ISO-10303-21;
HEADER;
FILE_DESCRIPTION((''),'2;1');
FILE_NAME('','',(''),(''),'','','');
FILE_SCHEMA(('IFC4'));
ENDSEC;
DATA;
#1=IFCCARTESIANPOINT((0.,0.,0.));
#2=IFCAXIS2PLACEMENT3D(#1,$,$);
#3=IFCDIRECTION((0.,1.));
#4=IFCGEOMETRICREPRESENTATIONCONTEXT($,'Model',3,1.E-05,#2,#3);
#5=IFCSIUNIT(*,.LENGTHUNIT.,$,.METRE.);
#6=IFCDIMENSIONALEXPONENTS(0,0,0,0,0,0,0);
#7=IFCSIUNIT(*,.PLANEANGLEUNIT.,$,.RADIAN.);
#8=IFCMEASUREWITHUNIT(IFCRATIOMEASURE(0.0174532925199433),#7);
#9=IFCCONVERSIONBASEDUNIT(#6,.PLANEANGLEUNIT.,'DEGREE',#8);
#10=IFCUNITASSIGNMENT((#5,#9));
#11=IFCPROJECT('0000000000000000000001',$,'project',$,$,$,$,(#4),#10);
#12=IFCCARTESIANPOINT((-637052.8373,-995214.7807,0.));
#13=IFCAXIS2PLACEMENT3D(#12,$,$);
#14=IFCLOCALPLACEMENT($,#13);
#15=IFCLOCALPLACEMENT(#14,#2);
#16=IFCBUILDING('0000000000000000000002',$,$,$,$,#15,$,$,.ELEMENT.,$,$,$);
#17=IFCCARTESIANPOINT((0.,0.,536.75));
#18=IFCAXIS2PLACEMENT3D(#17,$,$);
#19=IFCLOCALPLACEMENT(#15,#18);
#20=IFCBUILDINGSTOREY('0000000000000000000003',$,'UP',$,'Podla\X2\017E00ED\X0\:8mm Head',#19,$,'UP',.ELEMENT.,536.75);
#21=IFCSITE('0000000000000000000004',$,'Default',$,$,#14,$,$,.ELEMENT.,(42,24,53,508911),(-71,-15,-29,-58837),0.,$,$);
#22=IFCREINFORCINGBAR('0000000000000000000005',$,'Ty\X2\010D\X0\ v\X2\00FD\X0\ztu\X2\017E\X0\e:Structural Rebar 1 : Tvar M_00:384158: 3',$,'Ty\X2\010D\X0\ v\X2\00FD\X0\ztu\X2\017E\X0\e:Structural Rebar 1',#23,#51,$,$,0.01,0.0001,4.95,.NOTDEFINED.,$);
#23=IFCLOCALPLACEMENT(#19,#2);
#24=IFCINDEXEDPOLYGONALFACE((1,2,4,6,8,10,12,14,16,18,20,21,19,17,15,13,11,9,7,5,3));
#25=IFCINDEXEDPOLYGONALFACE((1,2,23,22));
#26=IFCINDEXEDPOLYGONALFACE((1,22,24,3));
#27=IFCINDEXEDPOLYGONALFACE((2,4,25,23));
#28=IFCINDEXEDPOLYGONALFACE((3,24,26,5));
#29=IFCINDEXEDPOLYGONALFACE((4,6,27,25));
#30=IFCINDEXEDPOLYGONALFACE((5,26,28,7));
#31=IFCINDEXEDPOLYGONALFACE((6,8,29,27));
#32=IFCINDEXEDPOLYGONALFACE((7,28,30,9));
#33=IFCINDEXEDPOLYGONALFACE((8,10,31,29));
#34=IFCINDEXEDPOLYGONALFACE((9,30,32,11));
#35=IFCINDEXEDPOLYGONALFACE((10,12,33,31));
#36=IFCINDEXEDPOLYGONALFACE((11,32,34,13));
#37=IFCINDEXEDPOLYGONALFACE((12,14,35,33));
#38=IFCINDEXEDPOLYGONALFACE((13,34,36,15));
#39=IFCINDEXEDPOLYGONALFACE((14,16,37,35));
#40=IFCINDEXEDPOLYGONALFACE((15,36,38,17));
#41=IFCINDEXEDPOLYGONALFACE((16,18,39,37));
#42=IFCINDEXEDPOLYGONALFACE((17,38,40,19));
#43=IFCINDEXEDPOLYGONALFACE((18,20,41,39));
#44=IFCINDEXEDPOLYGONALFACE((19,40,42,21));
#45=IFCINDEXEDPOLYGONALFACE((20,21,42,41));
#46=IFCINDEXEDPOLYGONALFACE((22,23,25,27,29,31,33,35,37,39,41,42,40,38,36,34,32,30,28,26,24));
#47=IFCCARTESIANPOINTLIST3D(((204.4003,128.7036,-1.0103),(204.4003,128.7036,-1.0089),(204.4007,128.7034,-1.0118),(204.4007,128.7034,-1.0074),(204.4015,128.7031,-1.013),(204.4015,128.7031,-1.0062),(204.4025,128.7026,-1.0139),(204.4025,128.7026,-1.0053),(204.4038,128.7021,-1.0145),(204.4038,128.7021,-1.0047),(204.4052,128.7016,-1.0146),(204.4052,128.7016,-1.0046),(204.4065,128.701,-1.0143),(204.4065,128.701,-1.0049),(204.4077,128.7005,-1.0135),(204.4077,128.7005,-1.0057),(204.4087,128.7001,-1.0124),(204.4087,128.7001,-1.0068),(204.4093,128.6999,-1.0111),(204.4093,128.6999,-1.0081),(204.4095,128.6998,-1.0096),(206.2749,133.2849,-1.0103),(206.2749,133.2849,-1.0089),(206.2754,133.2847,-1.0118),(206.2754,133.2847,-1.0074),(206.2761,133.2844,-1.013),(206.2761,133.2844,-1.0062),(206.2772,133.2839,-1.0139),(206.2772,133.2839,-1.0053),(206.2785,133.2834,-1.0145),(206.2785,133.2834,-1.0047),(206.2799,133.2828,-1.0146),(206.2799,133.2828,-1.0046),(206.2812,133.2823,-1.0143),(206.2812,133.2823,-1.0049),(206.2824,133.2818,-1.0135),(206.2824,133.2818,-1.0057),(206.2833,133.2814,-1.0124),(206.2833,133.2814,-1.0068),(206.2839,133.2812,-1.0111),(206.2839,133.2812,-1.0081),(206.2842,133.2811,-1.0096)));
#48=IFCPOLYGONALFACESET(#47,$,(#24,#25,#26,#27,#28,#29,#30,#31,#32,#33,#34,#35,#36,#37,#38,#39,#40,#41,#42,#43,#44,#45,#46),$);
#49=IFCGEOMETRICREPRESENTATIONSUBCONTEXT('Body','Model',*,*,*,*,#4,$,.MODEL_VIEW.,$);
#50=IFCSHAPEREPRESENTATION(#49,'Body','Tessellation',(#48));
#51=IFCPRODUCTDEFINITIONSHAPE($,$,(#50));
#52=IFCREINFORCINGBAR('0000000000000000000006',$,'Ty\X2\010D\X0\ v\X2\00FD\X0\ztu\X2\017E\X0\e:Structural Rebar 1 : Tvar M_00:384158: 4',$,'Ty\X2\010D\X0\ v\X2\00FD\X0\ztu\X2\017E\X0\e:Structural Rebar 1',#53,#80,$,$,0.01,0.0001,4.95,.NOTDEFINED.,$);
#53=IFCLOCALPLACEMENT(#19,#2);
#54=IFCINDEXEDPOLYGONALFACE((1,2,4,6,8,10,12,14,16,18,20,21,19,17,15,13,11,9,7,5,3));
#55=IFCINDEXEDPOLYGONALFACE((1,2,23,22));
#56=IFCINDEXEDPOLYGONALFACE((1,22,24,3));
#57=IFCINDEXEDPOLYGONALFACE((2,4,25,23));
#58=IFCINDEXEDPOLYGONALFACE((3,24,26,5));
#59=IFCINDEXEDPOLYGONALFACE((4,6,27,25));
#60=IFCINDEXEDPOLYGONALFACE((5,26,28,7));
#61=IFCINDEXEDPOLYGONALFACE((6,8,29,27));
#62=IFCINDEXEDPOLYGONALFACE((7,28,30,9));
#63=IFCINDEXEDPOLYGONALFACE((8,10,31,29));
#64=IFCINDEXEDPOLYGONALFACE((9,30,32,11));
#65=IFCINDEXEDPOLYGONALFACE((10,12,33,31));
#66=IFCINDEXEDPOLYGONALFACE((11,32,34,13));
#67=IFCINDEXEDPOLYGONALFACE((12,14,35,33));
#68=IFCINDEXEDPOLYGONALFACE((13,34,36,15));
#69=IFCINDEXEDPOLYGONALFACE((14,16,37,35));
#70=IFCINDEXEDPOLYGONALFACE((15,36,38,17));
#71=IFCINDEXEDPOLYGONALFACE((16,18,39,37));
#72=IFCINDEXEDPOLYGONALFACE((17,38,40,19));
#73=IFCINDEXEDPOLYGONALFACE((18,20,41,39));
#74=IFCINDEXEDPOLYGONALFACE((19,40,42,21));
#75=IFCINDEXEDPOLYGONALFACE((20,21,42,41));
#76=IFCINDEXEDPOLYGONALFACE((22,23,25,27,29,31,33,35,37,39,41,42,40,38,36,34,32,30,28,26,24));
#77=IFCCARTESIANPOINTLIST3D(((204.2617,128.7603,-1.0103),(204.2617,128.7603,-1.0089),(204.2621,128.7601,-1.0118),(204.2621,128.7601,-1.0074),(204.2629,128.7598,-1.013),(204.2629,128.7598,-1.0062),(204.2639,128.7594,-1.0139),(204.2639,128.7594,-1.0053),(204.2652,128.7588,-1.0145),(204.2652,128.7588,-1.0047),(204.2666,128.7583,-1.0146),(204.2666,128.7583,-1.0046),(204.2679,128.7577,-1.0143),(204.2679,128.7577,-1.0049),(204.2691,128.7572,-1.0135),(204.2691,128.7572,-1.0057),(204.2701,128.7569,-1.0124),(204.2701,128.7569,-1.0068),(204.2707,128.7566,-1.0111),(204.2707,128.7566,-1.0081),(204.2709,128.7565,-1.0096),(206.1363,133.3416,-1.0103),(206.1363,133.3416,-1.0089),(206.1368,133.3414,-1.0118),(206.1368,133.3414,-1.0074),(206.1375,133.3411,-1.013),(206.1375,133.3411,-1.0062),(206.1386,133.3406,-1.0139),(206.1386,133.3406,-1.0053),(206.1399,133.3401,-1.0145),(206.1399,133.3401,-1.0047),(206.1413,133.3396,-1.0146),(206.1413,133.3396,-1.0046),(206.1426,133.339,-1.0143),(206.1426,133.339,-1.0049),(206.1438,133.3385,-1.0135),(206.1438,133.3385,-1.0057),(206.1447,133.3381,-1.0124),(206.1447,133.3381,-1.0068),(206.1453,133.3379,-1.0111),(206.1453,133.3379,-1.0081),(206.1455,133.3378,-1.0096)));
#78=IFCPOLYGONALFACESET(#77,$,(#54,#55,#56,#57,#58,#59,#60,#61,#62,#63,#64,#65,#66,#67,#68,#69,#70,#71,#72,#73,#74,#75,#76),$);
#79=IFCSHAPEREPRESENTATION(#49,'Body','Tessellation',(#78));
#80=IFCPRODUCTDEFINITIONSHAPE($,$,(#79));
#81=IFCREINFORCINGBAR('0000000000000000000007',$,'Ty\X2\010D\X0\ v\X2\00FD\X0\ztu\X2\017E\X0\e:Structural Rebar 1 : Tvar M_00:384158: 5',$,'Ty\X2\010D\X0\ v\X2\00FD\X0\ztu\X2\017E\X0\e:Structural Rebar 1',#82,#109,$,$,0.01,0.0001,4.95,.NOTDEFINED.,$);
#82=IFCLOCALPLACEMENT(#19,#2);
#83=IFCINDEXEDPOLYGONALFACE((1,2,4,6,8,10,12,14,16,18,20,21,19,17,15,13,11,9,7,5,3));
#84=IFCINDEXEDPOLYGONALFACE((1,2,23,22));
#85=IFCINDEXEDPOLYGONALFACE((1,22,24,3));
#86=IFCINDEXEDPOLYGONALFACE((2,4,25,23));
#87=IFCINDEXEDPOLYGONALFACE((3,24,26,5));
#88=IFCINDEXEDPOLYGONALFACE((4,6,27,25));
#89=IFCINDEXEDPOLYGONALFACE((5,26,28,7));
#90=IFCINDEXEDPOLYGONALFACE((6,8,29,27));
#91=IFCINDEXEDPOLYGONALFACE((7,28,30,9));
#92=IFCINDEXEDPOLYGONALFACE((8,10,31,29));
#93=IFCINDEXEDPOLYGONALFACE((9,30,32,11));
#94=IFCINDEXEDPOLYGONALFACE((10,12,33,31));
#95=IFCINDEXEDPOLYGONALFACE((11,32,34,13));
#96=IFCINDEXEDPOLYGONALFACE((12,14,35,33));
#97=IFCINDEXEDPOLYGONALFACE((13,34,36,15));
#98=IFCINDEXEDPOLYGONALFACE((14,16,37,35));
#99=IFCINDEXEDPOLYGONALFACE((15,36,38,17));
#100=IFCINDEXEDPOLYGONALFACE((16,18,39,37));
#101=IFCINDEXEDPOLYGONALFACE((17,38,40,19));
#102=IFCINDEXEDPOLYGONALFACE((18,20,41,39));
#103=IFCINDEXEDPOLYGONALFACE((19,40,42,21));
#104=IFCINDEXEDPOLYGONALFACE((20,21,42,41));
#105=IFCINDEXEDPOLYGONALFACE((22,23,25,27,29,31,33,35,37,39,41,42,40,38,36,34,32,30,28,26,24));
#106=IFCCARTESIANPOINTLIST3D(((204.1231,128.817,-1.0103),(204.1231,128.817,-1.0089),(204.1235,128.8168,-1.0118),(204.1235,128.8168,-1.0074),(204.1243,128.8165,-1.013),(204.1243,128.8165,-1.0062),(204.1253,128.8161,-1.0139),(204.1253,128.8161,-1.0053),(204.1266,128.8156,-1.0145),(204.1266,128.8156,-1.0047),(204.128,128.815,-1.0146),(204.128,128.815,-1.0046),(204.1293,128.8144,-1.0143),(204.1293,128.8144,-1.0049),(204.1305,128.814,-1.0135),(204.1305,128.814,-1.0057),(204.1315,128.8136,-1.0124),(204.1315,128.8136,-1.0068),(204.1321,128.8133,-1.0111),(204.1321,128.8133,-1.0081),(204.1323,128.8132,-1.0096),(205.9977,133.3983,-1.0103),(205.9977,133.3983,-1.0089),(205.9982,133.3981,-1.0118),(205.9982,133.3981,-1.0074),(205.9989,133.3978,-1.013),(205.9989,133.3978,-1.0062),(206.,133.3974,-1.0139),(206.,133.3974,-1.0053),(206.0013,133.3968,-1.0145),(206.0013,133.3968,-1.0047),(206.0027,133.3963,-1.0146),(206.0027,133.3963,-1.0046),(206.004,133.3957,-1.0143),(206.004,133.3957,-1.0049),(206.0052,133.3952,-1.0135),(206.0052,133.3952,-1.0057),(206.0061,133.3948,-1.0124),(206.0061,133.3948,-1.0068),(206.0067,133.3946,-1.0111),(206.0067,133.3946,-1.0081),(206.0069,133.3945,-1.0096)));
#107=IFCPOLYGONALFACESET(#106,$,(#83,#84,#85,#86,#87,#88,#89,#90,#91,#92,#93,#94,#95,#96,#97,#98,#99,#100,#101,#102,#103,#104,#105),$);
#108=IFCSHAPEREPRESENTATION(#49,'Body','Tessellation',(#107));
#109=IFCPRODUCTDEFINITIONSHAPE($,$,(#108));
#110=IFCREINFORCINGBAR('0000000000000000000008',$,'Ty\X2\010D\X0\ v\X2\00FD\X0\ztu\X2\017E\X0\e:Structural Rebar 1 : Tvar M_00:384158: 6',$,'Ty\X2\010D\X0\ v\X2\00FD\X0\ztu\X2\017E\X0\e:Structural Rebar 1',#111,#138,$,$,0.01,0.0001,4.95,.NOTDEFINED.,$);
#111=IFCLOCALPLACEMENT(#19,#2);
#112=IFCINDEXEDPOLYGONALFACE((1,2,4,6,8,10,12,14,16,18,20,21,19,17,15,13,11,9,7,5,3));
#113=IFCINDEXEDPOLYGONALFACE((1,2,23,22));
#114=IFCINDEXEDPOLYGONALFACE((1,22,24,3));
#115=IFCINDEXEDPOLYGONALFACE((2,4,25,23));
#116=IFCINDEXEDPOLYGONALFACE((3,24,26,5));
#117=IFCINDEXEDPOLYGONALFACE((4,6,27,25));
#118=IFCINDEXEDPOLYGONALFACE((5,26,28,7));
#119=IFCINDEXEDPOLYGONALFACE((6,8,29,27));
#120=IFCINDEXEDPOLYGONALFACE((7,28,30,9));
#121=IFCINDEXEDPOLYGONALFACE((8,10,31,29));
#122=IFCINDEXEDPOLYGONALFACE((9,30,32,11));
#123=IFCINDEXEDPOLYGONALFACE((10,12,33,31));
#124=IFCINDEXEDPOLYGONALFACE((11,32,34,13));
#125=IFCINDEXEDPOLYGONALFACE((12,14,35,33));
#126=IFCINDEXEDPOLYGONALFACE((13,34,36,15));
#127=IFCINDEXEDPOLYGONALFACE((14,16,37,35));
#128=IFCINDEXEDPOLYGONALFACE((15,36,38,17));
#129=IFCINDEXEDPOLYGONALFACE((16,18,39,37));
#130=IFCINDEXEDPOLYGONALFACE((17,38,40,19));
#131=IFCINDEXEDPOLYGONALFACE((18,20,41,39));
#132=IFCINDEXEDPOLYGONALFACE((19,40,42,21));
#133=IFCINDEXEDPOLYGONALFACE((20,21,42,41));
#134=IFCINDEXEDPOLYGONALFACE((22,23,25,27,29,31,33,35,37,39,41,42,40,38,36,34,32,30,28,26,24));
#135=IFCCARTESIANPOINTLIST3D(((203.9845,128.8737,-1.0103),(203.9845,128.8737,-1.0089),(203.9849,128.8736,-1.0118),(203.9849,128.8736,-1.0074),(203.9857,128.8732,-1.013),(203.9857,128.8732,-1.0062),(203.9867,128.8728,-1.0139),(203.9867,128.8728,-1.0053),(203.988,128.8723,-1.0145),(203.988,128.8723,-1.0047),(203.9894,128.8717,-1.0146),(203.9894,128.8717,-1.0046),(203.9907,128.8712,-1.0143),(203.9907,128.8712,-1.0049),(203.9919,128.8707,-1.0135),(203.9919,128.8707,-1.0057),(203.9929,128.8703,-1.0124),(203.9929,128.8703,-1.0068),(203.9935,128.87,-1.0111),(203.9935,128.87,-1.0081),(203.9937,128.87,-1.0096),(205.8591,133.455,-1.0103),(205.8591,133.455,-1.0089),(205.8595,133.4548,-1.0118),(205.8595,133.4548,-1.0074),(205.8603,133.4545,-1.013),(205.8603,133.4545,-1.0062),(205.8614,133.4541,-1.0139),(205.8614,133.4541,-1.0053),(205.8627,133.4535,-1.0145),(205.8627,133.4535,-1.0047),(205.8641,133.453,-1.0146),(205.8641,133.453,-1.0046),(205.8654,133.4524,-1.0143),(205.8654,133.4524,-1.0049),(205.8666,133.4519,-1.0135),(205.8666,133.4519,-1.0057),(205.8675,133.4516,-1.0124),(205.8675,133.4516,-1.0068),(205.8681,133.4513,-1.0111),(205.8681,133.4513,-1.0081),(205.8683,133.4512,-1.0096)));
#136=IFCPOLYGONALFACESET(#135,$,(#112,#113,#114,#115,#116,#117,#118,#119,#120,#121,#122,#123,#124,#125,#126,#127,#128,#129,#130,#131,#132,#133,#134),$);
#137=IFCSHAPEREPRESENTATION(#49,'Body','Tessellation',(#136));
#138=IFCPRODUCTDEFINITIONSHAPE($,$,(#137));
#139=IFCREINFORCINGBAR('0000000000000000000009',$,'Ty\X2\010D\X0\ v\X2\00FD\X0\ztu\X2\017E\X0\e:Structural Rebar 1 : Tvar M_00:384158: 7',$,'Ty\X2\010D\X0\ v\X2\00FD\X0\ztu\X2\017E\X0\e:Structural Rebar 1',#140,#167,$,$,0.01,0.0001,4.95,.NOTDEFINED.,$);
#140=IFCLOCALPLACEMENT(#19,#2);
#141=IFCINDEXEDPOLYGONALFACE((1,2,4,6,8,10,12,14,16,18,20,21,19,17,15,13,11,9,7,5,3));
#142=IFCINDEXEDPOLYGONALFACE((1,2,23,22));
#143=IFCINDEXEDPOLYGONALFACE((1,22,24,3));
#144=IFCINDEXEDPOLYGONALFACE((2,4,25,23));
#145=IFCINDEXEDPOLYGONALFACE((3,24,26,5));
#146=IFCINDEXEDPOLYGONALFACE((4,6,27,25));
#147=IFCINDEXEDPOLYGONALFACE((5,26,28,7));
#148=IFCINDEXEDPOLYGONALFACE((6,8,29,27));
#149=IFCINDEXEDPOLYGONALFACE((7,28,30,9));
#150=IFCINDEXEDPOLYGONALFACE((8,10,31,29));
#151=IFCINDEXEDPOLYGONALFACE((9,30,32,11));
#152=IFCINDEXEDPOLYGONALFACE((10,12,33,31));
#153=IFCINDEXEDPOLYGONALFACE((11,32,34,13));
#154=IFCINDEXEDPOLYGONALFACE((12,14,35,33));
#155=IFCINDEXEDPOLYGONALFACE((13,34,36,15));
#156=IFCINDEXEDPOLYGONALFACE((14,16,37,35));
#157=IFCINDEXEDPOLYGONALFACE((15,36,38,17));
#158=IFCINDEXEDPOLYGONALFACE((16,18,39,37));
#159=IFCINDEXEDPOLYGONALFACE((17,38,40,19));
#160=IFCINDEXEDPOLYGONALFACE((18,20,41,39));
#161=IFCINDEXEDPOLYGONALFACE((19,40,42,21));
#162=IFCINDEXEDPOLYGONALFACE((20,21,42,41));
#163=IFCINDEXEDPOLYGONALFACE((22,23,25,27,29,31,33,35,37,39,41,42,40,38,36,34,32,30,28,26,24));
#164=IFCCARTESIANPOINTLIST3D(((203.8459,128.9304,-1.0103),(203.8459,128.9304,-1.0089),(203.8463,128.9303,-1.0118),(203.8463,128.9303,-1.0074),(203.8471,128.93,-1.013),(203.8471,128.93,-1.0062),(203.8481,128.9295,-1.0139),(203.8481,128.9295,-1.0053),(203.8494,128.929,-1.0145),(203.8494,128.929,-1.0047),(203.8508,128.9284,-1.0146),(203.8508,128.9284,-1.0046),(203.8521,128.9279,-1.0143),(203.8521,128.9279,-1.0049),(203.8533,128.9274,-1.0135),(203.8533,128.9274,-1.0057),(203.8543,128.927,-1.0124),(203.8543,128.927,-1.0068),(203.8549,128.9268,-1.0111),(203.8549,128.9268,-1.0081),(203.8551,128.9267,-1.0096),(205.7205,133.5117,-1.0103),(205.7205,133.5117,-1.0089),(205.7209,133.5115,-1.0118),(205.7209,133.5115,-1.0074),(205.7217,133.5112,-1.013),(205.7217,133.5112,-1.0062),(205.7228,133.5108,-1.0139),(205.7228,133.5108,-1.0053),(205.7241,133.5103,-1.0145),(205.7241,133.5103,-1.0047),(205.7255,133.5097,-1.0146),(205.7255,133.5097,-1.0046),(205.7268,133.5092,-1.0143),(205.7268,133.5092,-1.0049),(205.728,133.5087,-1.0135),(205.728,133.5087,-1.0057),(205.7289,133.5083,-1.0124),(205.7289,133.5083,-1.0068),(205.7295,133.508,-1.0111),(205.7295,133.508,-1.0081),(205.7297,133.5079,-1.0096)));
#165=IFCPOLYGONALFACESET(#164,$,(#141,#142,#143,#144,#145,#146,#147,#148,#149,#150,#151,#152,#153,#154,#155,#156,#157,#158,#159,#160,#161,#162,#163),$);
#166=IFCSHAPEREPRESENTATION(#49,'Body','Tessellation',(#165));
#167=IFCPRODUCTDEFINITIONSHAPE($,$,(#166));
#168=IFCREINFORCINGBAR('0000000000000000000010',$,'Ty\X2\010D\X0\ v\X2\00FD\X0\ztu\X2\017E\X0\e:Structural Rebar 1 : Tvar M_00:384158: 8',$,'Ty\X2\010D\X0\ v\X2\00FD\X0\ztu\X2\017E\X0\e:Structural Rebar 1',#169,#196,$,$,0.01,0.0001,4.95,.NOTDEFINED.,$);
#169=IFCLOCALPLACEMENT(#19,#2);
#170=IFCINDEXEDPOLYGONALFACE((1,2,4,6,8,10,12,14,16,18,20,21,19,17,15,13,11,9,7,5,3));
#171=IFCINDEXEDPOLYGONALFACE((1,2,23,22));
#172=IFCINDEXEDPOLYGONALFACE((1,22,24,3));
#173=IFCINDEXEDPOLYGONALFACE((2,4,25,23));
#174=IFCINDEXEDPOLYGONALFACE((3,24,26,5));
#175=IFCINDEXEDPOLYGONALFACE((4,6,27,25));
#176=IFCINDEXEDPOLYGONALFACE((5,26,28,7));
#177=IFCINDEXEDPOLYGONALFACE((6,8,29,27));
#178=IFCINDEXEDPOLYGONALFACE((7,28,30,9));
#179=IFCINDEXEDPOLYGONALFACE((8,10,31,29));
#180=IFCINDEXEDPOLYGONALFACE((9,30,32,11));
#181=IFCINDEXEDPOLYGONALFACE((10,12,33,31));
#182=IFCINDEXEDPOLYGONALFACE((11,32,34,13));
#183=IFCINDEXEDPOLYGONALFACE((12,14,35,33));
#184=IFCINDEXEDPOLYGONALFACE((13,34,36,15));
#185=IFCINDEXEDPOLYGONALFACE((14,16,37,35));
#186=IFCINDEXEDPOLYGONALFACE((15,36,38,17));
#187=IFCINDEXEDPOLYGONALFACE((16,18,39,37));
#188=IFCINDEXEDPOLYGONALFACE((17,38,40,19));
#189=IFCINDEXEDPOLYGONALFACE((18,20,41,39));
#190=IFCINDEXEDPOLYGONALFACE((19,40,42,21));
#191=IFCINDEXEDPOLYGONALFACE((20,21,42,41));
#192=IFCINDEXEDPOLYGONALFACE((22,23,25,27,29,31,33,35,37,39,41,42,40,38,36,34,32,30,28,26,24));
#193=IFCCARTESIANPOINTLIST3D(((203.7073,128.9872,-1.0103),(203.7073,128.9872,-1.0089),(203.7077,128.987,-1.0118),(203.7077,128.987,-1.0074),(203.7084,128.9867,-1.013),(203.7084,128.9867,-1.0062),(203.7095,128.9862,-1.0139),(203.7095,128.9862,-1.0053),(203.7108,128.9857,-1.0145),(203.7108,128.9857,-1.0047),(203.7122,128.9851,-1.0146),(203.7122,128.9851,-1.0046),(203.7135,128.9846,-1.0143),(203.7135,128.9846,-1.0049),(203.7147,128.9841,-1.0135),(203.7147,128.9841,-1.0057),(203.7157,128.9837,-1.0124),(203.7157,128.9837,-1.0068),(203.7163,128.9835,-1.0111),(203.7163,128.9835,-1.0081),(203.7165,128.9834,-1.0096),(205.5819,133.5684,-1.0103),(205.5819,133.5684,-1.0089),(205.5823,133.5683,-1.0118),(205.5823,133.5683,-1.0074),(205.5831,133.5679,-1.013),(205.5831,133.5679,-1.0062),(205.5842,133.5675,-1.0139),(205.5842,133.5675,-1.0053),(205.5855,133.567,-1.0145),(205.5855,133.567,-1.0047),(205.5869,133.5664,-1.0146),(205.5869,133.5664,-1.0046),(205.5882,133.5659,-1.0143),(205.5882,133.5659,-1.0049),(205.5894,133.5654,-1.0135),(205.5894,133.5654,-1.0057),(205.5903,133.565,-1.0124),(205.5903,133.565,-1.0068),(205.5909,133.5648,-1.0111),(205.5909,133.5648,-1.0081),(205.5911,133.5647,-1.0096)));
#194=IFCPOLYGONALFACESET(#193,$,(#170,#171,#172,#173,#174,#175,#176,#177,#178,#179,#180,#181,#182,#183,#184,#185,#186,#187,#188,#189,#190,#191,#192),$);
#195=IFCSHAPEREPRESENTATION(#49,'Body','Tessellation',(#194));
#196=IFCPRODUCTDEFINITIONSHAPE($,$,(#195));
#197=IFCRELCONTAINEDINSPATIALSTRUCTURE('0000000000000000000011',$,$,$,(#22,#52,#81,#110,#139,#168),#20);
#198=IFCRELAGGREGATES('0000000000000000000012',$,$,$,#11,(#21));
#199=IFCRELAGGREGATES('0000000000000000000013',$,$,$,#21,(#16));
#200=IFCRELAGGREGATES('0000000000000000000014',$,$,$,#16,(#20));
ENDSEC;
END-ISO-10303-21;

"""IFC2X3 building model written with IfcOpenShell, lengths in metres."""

from ifc_helpers import new_model, entity, si_unit, converted_unit, direction, frame, origin, place, context, subcontext, project, spatial, element, save


model = new_model("IFC2X3")

# Units and contexts
model_context = context("Model", 3, precision=1e-05, world=origin(), true_north=direction((0.0, 1.0)))
body_context = subcontext(model_context, "Body", "Model", "MODEL_VIEW")
ifc_project = project(units=[si_unit("LENGTHUNIT", "METRE"), converted_unit("PLANEANGLEUNIT", "DEGREE", entity("IfcRatioMeasure", 0.0174532925199433), si_unit("PLANEANGLEUNIT", "RADIAN"), dimensions=[0, 0, 0, 0, 0, 0, 0])], contexts=[model_context])

# Site, building, storey
site_placement = place(None, frame((-637052.8373, -995214.7807, 0.0)))
site = spatial("IfcSite", under=ifc_project, at=site_placement, Name="Default", CompositionType="ELEMENT", RefLatitude=(42, 24, 53, 508911), RefLongitude=(-71, -15, -29, -58837), RefElevation=0.0)
building_placement = place(site_placement, origin())
building = spatial("IfcBuilding", under=site, at=building_placement, CompositionType="ELEMENT")
storey_placement = place(building_placement, frame((0.0, 0.0, 536.75)))
storey = spatial("IfcBuildingStorey", under=building, at=storey_placement, Name="UP", ObjectType="Podlaží:8mm Head", LongName="UP", CompositionType="ELEMENT", Elevation=536.75)

# Reinforcing bars
reinforcing_bar_1_placement = place(storey_placement, origin())
element("IfcReinforcingBar", 1, at=reinforcing_bar_1_placement, inside=storey, Name="Tyč výztuže:Structural Rebar 1 : Tvar M_00:384158: 3", ObjectType="Tyč výztuže:Structural Rebar 1", BarLength=4.95, BarRole="NOTDEFINED", CrossSectionArea=0.0001, NominalDiameter=0.01, context=body_context, shape_type="AdvancedSweptSolid", body=[
    entity("IfcSweptDiskSolid", entity("IfcCompositeCurve", [entity("IfcCompositeCurveSegment", "CONTINUOUS", True, entity("IfcPolyline", [entity("IfcCartesianPoint", [-206.2795, -133.283, 1.0096]), entity("IfcCartesianPoint", [-204.4048, -128.7017, 1.0096])]))], False), 0.005, None, 0.0, 1.0),
])
reinforcing_bar_2_placement = place(storey_placement, origin())
element("IfcReinforcingBar", 2, at=reinforcing_bar_2_placement, inside=storey, Name="Tyč výztuže:Structural Rebar 1 : Tvar M_00:384158: 4", ObjectType="Tyč výztuže:Structural Rebar 1", BarLength=4.95, BarRole="NOTDEFINED", CrossSectionArea=0.0001, NominalDiameter=0.01, context=body_context, shape_type="AdvancedSweptSolid", body=[
    entity("IfcSweptDiskSolid", entity("IfcCompositeCurve", [entity("IfcCompositeCurveSegment", "CONTINUOUS", True, entity("IfcPolyline", [entity("IfcCartesianPoint", [-206.1409, -133.3397, 1.0096]), entity("IfcCartesianPoint", [-204.2662, -128.7584, 1.0096])]))], False), 0.005, None, 0.0, 1.0),
])
reinforcing_bar_3_placement = place(storey_placement, origin())
element("IfcReinforcingBar", 3, at=reinforcing_bar_3_placement, inside=storey, Name="Tyč výztuže:Structural Rebar 1 : Tvar M_00:384158: 5", ObjectType="Tyč výztuže:Structural Rebar 1", BarLength=4.95, BarRole="NOTDEFINED", CrossSectionArea=0.0001, NominalDiameter=0.01, context=body_context, shape_type="AdvancedSweptSolid", body=[
    entity("IfcSweptDiskSolid", entity("IfcCompositeCurve", [entity("IfcCompositeCurveSegment", "CONTINUOUS", True, entity("IfcPolyline", [entity("IfcCartesianPoint", [-206.0023, -133.3964, 1.0096]), entity("IfcCartesianPoint", [-204.1276, -128.8151, 1.0096])]))], False), 0.005, None, 0.0, 1.0),
])
reinforcing_bar_4_placement = place(storey_placement, origin())
element("IfcReinforcingBar", 4, at=reinforcing_bar_4_placement, inside=storey, Name="Tyč výztuže:Structural Rebar 1 : Tvar M_00:384158: 6", ObjectType="Tyč výztuže:Structural Rebar 1", BarLength=4.95, BarRole="NOTDEFINED", CrossSectionArea=0.0001, NominalDiameter=0.01, context=body_context, shape_type="AdvancedSweptSolid", body=[
    entity("IfcSweptDiskSolid", entity("IfcCompositeCurve", [entity("IfcCompositeCurveSegment", "CONTINUOUS", True, entity("IfcPolyline", [entity("IfcCartesianPoint", [-205.8637, -133.4531, 1.0096]), entity("IfcCartesianPoint", [-203.989, -128.8719, 1.0096])]))], False), 0.005, None, 0.0, 1.0),
])
reinforcing_bar_5_placement = place(storey_placement, origin())
element("IfcReinforcingBar", 5, at=reinforcing_bar_5_placement, inside=storey, Name="Tyč výztuže:Structural Rebar 1 : Tvar M_00:384158: 7", ObjectType="Tyč výztuže:Structural Rebar 1", BarLength=4.95, BarRole="NOTDEFINED", CrossSectionArea=0.0001, NominalDiameter=0.01, context=body_context, shape_type="AdvancedSweptSolid", body=[
    entity("IfcSweptDiskSolid", entity("IfcCompositeCurve", [entity("IfcCompositeCurveSegment", "CONTINUOUS", True, entity("IfcPolyline", [entity("IfcCartesianPoint", [-205.7251, -133.5098, 1.0096]), entity("IfcCartesianPoint", [-203.8504, -128.9286, 1.0096])]))], False), 0.005, None, 0.0, 1.0),
])
reinforcing_bar_6_placement = place(storey_placement, origin())
element("IfcReinforcingBar", 6, at=reinforcing_bar_6_placement, inside=storey, Name="Tyč výztuže:Structural Rebar 1 : Tvar M_00:384158: 8", ObjectType="Tyč výztuže:Structural Rebar 1", BarLength=4.95, BarRole="NOTDEFINED", CrossSectionArea=0.0001, NominalDiameter=0.01, context=body_context, shape_type="AdvancedSweptSolid", body=[
    entity("IfcSweptDiskSolid", entity("IfcCompositeCurve", [entity("IfcCompositeCurveSegment", "CONTINUOUS", True, entity("IfcPolyline", [entity("IfcCartesianPoint", [-205.5865, -133.5666, 1.0096]), entity("IfcCartesianPoint", [-203.7118, -128.9853, 1.0096])]))], False), 0.005, None, 0.0, 1.0),
])

save(model, "model.ifc")
